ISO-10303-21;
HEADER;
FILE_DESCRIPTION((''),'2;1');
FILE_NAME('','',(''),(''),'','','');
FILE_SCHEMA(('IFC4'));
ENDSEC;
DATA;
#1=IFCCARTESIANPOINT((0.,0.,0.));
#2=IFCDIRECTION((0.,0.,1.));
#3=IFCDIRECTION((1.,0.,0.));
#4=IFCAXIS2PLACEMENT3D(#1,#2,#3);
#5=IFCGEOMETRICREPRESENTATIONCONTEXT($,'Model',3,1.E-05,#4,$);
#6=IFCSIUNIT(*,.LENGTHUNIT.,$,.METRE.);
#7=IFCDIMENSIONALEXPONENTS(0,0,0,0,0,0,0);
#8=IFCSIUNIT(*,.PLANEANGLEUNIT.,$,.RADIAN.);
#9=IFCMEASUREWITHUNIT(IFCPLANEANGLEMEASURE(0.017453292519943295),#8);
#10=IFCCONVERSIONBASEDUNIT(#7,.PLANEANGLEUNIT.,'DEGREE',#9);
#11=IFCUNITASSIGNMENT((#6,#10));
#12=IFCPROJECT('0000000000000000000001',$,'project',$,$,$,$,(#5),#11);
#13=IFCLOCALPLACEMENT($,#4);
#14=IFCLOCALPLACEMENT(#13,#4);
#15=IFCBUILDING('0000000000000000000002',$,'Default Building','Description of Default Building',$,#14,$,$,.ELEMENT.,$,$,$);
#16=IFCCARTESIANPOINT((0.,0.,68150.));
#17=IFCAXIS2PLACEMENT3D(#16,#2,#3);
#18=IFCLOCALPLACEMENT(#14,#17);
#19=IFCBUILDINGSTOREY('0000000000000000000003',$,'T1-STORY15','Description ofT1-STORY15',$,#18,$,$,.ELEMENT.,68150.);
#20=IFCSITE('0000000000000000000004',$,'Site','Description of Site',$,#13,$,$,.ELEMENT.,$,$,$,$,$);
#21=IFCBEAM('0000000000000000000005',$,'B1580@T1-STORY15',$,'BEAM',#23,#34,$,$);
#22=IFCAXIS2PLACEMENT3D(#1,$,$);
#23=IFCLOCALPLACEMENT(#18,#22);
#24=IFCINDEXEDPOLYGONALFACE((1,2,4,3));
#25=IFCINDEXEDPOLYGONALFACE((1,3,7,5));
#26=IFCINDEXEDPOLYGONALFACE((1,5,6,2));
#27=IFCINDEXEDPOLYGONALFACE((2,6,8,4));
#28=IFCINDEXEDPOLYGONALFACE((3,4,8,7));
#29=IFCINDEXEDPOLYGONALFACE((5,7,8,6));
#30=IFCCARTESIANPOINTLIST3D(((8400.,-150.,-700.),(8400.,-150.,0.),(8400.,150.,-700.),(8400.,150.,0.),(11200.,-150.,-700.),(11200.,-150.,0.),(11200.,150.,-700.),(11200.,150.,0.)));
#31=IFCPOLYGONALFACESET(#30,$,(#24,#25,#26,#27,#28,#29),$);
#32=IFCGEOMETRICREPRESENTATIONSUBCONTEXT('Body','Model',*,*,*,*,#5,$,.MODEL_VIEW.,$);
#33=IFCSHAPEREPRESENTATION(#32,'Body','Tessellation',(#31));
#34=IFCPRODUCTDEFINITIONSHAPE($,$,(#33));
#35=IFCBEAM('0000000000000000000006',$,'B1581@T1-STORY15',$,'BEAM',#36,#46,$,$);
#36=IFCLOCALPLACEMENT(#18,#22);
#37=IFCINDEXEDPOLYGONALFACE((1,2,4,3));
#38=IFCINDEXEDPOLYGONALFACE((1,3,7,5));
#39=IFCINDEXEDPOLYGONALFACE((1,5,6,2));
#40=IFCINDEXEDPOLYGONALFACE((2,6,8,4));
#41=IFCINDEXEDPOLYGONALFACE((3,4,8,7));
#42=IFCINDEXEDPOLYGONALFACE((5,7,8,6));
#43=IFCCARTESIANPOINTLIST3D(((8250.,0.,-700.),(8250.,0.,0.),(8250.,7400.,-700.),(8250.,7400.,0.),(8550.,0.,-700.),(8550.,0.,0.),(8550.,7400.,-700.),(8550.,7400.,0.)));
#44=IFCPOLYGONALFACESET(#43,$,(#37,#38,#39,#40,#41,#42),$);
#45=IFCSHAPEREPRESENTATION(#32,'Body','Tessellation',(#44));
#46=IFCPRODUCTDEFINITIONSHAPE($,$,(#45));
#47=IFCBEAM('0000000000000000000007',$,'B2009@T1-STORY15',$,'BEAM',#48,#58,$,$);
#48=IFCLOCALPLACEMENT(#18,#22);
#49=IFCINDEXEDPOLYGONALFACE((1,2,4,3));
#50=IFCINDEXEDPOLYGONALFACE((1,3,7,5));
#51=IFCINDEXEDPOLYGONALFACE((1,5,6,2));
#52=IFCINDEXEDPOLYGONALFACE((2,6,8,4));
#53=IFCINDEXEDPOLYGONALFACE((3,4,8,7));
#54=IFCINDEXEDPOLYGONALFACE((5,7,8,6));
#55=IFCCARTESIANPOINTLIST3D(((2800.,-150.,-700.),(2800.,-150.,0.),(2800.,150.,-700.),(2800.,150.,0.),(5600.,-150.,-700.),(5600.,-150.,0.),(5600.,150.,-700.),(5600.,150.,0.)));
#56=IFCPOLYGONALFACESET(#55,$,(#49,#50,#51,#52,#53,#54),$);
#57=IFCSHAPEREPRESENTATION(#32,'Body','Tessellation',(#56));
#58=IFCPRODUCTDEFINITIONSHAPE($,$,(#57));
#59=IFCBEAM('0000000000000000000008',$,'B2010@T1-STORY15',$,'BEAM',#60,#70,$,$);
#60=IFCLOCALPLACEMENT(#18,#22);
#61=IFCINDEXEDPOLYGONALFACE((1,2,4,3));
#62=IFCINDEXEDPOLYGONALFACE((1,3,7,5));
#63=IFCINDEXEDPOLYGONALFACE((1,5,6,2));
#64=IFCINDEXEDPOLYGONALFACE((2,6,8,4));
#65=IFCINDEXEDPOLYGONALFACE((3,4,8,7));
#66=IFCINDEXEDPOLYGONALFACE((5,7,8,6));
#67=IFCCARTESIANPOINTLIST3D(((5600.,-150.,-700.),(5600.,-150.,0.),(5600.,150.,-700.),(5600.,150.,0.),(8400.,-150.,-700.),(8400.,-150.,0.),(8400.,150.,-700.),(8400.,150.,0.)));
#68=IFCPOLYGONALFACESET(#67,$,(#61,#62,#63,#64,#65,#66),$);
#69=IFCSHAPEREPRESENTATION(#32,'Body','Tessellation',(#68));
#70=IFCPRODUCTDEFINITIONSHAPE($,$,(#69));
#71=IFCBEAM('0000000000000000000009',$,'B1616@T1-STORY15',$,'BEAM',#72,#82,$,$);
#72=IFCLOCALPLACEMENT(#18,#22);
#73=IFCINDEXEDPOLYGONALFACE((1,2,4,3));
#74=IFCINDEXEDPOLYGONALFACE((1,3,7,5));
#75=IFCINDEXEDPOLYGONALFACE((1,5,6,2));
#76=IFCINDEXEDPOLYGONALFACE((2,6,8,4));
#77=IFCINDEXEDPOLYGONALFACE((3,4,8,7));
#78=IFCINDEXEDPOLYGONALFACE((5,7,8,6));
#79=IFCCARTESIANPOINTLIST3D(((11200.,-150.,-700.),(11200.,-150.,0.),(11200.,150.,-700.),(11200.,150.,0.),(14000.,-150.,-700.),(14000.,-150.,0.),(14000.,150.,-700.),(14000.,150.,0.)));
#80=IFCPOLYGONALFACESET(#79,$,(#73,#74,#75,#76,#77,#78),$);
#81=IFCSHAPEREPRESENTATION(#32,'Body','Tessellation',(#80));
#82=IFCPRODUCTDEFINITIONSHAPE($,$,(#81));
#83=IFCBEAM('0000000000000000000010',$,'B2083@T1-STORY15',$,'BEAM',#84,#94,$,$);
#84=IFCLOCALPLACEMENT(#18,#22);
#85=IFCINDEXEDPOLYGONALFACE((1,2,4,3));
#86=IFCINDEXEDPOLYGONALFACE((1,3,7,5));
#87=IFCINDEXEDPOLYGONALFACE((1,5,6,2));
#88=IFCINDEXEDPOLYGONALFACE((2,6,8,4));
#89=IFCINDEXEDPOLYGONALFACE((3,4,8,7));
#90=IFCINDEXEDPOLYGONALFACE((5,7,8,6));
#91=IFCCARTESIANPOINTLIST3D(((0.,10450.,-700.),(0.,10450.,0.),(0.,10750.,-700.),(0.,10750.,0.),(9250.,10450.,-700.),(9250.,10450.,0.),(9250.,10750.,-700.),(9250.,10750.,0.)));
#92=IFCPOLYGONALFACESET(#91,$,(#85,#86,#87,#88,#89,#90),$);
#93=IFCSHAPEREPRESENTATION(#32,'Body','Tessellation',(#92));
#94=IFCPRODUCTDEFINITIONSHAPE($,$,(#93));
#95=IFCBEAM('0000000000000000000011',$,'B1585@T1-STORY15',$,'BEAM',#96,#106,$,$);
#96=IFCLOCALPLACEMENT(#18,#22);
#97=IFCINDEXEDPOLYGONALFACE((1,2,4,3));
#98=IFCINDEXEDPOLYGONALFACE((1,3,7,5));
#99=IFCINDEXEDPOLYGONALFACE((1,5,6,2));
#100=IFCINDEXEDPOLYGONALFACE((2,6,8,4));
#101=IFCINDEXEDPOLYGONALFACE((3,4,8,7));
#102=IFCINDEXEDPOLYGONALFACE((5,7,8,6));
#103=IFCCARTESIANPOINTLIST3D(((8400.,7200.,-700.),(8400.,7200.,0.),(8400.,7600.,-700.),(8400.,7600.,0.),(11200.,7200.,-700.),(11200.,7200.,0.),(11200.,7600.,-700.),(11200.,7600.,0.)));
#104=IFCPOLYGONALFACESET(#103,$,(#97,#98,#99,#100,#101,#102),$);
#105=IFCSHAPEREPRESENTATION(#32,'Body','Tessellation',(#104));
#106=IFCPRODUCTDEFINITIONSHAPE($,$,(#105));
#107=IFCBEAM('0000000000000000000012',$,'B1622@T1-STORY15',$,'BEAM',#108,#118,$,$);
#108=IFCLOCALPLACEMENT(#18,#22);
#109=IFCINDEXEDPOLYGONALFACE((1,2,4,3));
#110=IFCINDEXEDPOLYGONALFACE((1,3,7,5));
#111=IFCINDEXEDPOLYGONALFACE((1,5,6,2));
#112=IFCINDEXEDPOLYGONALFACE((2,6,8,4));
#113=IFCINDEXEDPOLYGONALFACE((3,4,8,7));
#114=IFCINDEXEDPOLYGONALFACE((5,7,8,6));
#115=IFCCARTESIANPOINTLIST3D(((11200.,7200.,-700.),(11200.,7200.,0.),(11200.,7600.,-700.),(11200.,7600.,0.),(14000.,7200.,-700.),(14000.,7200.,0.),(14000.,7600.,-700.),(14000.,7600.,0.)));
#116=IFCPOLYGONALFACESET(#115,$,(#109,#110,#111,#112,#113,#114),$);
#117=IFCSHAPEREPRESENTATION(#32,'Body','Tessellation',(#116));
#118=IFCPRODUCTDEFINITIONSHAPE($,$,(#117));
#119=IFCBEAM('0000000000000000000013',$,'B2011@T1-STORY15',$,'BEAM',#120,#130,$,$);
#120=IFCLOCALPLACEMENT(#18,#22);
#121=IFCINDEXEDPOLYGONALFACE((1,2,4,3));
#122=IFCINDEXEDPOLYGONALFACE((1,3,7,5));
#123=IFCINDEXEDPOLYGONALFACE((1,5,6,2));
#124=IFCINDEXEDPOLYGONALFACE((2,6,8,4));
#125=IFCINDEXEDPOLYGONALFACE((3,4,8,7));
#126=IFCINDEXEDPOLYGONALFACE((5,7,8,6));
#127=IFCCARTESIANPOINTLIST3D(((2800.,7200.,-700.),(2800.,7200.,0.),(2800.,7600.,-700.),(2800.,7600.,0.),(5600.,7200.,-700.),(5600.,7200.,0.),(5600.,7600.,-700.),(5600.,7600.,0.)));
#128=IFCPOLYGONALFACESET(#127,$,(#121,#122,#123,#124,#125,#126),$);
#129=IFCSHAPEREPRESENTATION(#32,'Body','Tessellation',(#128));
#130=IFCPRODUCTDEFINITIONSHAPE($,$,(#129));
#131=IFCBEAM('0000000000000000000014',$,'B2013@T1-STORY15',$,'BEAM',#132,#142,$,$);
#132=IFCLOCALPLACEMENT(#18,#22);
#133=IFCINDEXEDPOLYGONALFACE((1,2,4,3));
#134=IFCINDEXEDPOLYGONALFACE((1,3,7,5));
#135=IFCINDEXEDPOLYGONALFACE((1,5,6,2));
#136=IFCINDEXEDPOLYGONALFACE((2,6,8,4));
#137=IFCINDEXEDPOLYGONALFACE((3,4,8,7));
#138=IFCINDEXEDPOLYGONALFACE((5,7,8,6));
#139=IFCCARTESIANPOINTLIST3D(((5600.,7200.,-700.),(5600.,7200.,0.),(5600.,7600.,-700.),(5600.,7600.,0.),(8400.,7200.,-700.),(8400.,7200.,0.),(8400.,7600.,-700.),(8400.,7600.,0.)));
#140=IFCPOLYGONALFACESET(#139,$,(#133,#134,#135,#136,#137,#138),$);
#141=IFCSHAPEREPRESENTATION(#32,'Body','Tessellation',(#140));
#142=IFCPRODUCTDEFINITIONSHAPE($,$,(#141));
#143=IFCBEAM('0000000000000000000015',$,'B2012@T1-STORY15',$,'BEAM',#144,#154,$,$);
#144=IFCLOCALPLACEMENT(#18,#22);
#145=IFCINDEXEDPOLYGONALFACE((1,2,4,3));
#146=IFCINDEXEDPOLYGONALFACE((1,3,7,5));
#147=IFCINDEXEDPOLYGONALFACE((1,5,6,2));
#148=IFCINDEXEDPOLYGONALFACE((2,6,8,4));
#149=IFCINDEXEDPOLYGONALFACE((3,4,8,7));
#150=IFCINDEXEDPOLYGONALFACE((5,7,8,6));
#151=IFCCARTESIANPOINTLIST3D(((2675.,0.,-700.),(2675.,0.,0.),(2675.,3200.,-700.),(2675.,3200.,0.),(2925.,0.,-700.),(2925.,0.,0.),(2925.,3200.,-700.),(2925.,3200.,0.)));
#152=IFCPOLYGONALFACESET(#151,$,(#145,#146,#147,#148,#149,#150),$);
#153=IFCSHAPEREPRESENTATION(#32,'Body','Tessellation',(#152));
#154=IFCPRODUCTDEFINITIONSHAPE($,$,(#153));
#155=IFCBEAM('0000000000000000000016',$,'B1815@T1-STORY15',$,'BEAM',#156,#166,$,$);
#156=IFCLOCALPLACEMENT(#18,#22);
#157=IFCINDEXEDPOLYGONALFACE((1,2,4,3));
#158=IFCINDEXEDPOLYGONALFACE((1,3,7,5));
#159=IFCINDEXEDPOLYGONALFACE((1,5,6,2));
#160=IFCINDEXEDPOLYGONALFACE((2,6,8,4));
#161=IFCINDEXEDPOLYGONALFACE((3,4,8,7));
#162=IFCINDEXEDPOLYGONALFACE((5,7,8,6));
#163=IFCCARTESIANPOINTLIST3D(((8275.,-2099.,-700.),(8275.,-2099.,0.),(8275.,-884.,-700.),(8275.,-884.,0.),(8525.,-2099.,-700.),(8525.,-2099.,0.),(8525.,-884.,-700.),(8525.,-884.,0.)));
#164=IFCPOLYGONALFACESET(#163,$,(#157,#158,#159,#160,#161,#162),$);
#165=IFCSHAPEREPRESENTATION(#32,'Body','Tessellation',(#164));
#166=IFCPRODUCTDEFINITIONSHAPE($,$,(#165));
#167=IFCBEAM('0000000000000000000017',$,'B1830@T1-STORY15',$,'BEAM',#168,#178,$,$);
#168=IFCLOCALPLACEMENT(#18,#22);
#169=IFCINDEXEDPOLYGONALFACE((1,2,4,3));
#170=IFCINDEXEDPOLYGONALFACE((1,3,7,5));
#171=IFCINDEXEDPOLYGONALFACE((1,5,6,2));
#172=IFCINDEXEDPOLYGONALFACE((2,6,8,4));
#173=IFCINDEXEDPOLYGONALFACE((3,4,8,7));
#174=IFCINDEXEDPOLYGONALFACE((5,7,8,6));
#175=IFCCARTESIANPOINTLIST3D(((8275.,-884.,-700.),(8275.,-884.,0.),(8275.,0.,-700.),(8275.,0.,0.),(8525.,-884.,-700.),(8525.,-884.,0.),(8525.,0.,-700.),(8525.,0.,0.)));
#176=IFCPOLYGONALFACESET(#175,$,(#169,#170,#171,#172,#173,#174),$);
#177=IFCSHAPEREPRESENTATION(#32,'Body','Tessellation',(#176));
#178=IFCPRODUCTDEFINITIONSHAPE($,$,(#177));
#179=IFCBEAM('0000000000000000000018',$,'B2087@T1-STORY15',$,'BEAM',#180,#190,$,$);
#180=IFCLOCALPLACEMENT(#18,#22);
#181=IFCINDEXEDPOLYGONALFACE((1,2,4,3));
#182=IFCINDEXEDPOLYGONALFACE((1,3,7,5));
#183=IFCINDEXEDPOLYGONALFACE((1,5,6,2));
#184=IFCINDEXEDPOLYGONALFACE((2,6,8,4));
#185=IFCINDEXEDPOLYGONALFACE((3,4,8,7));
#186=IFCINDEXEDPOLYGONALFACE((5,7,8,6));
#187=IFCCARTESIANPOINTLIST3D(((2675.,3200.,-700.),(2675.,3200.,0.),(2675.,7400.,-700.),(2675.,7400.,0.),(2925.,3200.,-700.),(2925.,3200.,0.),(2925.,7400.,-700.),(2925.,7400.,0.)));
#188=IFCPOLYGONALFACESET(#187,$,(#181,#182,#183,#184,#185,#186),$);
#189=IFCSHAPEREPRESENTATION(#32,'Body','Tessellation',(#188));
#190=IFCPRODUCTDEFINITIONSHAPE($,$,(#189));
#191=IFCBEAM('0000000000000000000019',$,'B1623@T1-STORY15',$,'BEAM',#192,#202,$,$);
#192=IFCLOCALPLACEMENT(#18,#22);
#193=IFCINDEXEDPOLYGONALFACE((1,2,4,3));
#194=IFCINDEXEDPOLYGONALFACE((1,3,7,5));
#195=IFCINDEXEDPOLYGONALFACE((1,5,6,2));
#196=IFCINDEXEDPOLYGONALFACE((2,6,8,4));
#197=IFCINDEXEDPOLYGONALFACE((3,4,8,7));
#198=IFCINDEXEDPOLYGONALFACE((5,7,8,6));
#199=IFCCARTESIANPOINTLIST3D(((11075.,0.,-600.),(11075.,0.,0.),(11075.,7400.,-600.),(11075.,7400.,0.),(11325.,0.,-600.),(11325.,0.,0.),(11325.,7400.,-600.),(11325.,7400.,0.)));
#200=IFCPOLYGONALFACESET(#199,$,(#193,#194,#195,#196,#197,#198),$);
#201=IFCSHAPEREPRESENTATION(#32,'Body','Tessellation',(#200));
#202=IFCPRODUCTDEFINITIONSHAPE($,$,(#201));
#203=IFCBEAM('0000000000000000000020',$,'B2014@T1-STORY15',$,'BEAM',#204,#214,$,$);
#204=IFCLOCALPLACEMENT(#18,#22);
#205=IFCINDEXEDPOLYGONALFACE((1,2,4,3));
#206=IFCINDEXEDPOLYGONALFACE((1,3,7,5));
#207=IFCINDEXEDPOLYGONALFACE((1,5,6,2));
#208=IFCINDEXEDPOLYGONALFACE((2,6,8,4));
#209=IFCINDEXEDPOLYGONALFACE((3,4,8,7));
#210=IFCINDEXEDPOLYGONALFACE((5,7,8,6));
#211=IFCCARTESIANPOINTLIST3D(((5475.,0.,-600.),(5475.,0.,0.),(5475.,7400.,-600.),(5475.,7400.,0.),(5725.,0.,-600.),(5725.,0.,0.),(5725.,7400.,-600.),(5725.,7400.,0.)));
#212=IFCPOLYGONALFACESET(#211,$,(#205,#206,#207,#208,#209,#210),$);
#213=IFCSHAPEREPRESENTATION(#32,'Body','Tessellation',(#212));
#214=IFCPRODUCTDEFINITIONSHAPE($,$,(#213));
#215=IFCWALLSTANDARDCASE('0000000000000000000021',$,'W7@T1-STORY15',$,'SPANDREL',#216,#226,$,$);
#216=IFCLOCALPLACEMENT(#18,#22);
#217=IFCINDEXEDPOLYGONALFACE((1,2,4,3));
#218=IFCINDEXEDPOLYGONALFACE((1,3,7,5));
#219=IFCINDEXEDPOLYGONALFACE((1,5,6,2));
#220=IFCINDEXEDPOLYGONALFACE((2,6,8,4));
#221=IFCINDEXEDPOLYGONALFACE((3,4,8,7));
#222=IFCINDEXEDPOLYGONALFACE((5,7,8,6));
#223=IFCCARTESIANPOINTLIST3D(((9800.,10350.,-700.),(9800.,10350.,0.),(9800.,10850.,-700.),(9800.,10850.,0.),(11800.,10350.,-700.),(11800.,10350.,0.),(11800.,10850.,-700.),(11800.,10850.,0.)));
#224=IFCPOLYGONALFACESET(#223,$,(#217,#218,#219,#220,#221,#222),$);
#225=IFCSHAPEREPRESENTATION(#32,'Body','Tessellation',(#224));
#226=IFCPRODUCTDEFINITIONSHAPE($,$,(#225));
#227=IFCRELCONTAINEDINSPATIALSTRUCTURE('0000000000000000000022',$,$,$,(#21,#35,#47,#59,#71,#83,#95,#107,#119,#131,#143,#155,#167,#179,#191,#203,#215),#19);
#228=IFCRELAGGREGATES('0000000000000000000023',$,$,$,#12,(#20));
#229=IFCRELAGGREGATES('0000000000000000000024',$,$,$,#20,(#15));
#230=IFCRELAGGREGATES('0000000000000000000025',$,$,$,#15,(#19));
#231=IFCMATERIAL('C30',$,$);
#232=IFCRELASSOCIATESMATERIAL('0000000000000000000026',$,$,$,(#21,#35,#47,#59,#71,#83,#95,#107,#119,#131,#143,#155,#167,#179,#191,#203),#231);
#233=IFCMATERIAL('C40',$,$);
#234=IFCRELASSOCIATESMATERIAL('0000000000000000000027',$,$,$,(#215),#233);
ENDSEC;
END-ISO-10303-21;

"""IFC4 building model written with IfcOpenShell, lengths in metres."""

from ifc_helpers import new_model, entity, si_unit, converted_unit, frame, origin_with_axes, place, context, subcontext, project, spatial, indexed_curve, rectangle, outline, extrude, material, element, save


model = new_model("IFC4")

# Units and contexts
model_context = context("Model", 3, precision=1e-05, world=origin_with_axes())
body_context = subcontext(model_context, "Body", "Model", "MODEL_VIEW")
ifc_project = project(units=[si_unit("LENGTHUNIT", "METRE"), converted_unit("PLANEANGLEUNIT", "DEGREE", entity("IfcPlaneAngleMeasure", 0.017453292519943295), si_unit("PLANEANGLEUNIT", "RADIAN"), dimensions=[0, 0, 0, 0, 0, 0, 0])], contexts=[model_context])

# Site, building, storey
site_placement = place(None, origin_with_axes())
site = spatial("IfcSite", under=ifc_project, at=site_placement, Name="Site", Description="Description of Site", CompositionType="ELEMENT")
building_placement = place(site_placement, origin_with_axes())
building = spatial("IfcBuilding", under=site, at=building_placement, Name="Default Building", Description="Description of Default Building", CompositionType="ELEMENT")
storey_placement = place(building_placement, frame((0.0, 0.0, 68150.0), z_axis=(0.0, 0.0, 1.0), x_axis=(1.0, 0.0, 0.0)))
storey = spatial("IfcBuildingStorey", under=building, at=storey_placement, Name="T1-STORY15", Description="Description ofT1-STORY15", CompositionType="ELEMENT", Elevation=68150.0)

# Beams
ifc_material_1 = material(Name="C30")
beam_1_placement = place(storey_placement, frame((8400.0, 0.0, -350.0), z_axis=(1.0, 0.0, 0.0), x_axis=(0.0, 1.0, 0.0)))
element("IfcBeam", 1, at=beam_1_placement, inside=storey, material=ifc_material_1, Name="B1580@T1-STORY15", ObjectType="BEAM", context=body_context, shape_type="SweptSolid", body=[
    extrude(rectangle(XDim=300.0, YDim=700.0), origin_with_axes(), (0.0, 0.0, 1.0), 2800.0),
])
beam_2_placement = place(storey_placement, frame((8400.0, 0.0, -350.0), z_axis=(0.0, 1.0, 0.0), x_axis=(-1.0, 0.0, 0.0)))
element("IfcBeam", 2, at=beam_2_placement, inside=storey, material=ifc_material_1, Name="B1581@T1-STORY15", ObjectType="BEAM", context=body_context, shape_type="SweptSolid", body=[
    extrude(rectangle(XDim=300.0, YDim=700.0), origin_with_axes(), (0.0, 0.0, 1.0), 7400.0),
])
for number, where, z_axis, x_axis, name in (
    (3, (2800.0, 0.0, -350.0), (1.0, 0.0, 0.0), (0.0, 1.0, 0.0), "B2009@T1-STORY15"),
    (4, (5600.0, 0.0, -350.0), (1.0, 0.0, 0.0), (0.0, 1.0, 0.0), "B2010@T1-STORY15"),
    (5, (11200.0, 0.0, -350.0), (1.0, 0.0, 0.0), (0.0, 1.0, 0.0), "B1616@T1-STORY15"),
):
    element("IfcBeam", number, at=place(storey_placement, frame(where, z_axis=z_axis, x_axis=x_axis)), inside=storey, material=ifc_material_1, Name=name, ObjectType="BEAM", context=body_context, shape_type="SweptSolid", body=[
        extrude(rectangle(XDim=300.0, YDim=700.0), origin_with_axes(), (0.0, 0.0, 1.0), 2800.0),
    ])
beam_3_placement = place(storey_placement, frame((0.0, 10600.0, -350.0), z_axis=(1.0, 0.0, 0.0), x_axis=(0.0, 1.0, 0.0)))
element("IfcBeam", 6, at=beam_3_placement, inside=storey, material=ifc_material_1, Name="B2083@T1-STORY15", ObjectType="BEAM", context=body_context, shape_type="SweptSolid", body=[
    extrude(rectangle(XDim=300.0, YDim=700.0), origin_with_axes(), (0.0, 0.0, 1.0), 9250.0),
])
for number, where, z_axis, x_axis, name in (
    (7, (8400.0, 7400.0, -350.0), (1.0, 0.0, 0.0), (0.0, 1.0, 0.0), "B1585@T1-STORY15"),
    (8, (11200.0, 7400.0, -350.0), (1.0, 0.0, 0.0), (0.0, 1.0, 0.0), "B1622@T1-STORY15"),
    (9, (2800.0, 7400.0, -350.0), (1.0, 0.0, 0.0), (0.0, 1.0, 0.0), "B2011@T1-STORY15"),
    (10, (5600.0, 7400.0, -350.0), (1.0, 0.0, 0.0), (0.0, 1.0, 0.0), "B2013@T1-STORY15"),
):
    element("IfcBeam", number, at=place(storey_placement, frame(where, z_axis=z_axis, x_axis=x_axis)), inside=storey, material=ifc_material_1, Name=name, ObjectType="BEAM", context=body_context, shape_type="SweptSolid", body=[
        extrude(rectangle(XDim=400.0, YDim=700.0), origin_with_axes(), (0.0, 0.0, 1.0), 2800.0),
    ])
beam_4_placement = place(storey_placement, frame((2800.0, 0.0, -350.0), z_axis=(0.0, 1.0, 0.0), x_axis=(-1.0, 0.0, 0.0)))
element("IfcBeam", 11, at=beam_4_placement, inside=storey, material=ifc_material_1, Name="B2012@T1-STORY15", ObjectType="BEAM", context=body_context, shape_type="SweptSolid", body=[
    extrude(rectangle(XDim=250.0, YDim=700.0), origin_with_axes(), (0.0, 0.0, 1.0), 3200.0),
])
beam_5_placement = place(storey_placement, frame((8400.0, -2099.0, -350.0), z_axis=(0.0, 1.0, 0.0), x_axis=(-1.0, 0.0, 0.0)))
element("IfcBeam", 12, at=beam_5_placement, inside=storey, material=ifc_material_1, Name="B1815@T1-STORY15", ObjectType="BEAM", context=body_context, shape_type="SweptSolid", body=[
    extrude(rectangle(XDim=250.0, YDim=700.0), origin_with_axes(), (0.0, 0.0, 1.0), 1215.0),
])
beam_6_placement = place(storey_placement, frame((8400.0, -884.0, -350.0), z_axis=(0.0, 1.0, 0.0), x_axis=(-1.0, 0.0, 0.0)))
element("IfcBeam", 13, at=beam_6_placement, inside=storey, material=ifc_material_1, Name="B1830@T1-STORY15", ObjectType="BEAM", context=body_context, shape_type="SweptSolid", body=[
    extrude(rectangle(XDim=250.0, YDim=700.0), origin_with_axes(), (0.0, 0.0, 1.0), 884.0),
])
beam_7_placement = place(storey_placement, frame((2800.0, 3200.0, -350.0), z_axis=(0.0, 1.0, 0.0), x_axis=(-1.0, 0.0, 0.0)))
element("IfcBeam", 14, at=beam_7_placement, inside=storey, material=ifc_material_1, Name="B2087@T1-STORY15", ObjectType="BEAM", context=body_context, shape_type="SweptSolid", body=[
    extrude(rectangle(XDim=250.0, YDim=700.0), origin_with_axes(), (0.0, 0.0, 1.0), 4200.0),
])
for number, where, z_axis, x_axis, name in (
    (15, (11200.0, 0.0, -300.0), (0.0, 1.0, 0.0), (-1.0, 0.0, 0.0), "B1623@T1-STORY15"),
    (16, (5600.0, 0.0, -300.0), (0.0, 1.0, 0.0), (-1.0, 0.0, 0.0), "B2014@T1-STORY15"),
):
    element("IfcBeam", number, at=place(storey_placement, frame(where, z_axis=z_axis, x_axis=x_axis)), inside=storey, material=ifc_material_1, Name=name, ObjectType="BEAM", context=body_context, shape_type="SweptSolid", body=[
        extrude(rectangle(XDim=250.0, YDim=600.0), origin_with_axes(), (0.0, 0.0, 1.0), 7400.0),
    ])
ifc_material_2 = material(Name="C40")

# Wall
wall_1_placement = place(storey_placement, frame((9800.0, 10600.0, -700.0), z_axis=(0.0, 0.0, 1.0), x_axis=(1.0, 0.0, 0.0)))
element("IfcWallStandardCase", 17, at=wall_1_placement, inside=storey, material=ifc_material_2, Name="W7@T1-STORY15", ObjectType="SPANDREL", context=body_context, shape_type="SweptSolid", body=[
    extrude(outline(indexed_curve([(0.0, -250.0), (0.0, 250.0), (2000.0, 250.0), (2000.0, -250.0), (0.0, -250.0)], self_intersect=False)), origin_with_axes(), (0.0, 0.0, 1.0), 700.0),
])

save(model, "model.ifc")
